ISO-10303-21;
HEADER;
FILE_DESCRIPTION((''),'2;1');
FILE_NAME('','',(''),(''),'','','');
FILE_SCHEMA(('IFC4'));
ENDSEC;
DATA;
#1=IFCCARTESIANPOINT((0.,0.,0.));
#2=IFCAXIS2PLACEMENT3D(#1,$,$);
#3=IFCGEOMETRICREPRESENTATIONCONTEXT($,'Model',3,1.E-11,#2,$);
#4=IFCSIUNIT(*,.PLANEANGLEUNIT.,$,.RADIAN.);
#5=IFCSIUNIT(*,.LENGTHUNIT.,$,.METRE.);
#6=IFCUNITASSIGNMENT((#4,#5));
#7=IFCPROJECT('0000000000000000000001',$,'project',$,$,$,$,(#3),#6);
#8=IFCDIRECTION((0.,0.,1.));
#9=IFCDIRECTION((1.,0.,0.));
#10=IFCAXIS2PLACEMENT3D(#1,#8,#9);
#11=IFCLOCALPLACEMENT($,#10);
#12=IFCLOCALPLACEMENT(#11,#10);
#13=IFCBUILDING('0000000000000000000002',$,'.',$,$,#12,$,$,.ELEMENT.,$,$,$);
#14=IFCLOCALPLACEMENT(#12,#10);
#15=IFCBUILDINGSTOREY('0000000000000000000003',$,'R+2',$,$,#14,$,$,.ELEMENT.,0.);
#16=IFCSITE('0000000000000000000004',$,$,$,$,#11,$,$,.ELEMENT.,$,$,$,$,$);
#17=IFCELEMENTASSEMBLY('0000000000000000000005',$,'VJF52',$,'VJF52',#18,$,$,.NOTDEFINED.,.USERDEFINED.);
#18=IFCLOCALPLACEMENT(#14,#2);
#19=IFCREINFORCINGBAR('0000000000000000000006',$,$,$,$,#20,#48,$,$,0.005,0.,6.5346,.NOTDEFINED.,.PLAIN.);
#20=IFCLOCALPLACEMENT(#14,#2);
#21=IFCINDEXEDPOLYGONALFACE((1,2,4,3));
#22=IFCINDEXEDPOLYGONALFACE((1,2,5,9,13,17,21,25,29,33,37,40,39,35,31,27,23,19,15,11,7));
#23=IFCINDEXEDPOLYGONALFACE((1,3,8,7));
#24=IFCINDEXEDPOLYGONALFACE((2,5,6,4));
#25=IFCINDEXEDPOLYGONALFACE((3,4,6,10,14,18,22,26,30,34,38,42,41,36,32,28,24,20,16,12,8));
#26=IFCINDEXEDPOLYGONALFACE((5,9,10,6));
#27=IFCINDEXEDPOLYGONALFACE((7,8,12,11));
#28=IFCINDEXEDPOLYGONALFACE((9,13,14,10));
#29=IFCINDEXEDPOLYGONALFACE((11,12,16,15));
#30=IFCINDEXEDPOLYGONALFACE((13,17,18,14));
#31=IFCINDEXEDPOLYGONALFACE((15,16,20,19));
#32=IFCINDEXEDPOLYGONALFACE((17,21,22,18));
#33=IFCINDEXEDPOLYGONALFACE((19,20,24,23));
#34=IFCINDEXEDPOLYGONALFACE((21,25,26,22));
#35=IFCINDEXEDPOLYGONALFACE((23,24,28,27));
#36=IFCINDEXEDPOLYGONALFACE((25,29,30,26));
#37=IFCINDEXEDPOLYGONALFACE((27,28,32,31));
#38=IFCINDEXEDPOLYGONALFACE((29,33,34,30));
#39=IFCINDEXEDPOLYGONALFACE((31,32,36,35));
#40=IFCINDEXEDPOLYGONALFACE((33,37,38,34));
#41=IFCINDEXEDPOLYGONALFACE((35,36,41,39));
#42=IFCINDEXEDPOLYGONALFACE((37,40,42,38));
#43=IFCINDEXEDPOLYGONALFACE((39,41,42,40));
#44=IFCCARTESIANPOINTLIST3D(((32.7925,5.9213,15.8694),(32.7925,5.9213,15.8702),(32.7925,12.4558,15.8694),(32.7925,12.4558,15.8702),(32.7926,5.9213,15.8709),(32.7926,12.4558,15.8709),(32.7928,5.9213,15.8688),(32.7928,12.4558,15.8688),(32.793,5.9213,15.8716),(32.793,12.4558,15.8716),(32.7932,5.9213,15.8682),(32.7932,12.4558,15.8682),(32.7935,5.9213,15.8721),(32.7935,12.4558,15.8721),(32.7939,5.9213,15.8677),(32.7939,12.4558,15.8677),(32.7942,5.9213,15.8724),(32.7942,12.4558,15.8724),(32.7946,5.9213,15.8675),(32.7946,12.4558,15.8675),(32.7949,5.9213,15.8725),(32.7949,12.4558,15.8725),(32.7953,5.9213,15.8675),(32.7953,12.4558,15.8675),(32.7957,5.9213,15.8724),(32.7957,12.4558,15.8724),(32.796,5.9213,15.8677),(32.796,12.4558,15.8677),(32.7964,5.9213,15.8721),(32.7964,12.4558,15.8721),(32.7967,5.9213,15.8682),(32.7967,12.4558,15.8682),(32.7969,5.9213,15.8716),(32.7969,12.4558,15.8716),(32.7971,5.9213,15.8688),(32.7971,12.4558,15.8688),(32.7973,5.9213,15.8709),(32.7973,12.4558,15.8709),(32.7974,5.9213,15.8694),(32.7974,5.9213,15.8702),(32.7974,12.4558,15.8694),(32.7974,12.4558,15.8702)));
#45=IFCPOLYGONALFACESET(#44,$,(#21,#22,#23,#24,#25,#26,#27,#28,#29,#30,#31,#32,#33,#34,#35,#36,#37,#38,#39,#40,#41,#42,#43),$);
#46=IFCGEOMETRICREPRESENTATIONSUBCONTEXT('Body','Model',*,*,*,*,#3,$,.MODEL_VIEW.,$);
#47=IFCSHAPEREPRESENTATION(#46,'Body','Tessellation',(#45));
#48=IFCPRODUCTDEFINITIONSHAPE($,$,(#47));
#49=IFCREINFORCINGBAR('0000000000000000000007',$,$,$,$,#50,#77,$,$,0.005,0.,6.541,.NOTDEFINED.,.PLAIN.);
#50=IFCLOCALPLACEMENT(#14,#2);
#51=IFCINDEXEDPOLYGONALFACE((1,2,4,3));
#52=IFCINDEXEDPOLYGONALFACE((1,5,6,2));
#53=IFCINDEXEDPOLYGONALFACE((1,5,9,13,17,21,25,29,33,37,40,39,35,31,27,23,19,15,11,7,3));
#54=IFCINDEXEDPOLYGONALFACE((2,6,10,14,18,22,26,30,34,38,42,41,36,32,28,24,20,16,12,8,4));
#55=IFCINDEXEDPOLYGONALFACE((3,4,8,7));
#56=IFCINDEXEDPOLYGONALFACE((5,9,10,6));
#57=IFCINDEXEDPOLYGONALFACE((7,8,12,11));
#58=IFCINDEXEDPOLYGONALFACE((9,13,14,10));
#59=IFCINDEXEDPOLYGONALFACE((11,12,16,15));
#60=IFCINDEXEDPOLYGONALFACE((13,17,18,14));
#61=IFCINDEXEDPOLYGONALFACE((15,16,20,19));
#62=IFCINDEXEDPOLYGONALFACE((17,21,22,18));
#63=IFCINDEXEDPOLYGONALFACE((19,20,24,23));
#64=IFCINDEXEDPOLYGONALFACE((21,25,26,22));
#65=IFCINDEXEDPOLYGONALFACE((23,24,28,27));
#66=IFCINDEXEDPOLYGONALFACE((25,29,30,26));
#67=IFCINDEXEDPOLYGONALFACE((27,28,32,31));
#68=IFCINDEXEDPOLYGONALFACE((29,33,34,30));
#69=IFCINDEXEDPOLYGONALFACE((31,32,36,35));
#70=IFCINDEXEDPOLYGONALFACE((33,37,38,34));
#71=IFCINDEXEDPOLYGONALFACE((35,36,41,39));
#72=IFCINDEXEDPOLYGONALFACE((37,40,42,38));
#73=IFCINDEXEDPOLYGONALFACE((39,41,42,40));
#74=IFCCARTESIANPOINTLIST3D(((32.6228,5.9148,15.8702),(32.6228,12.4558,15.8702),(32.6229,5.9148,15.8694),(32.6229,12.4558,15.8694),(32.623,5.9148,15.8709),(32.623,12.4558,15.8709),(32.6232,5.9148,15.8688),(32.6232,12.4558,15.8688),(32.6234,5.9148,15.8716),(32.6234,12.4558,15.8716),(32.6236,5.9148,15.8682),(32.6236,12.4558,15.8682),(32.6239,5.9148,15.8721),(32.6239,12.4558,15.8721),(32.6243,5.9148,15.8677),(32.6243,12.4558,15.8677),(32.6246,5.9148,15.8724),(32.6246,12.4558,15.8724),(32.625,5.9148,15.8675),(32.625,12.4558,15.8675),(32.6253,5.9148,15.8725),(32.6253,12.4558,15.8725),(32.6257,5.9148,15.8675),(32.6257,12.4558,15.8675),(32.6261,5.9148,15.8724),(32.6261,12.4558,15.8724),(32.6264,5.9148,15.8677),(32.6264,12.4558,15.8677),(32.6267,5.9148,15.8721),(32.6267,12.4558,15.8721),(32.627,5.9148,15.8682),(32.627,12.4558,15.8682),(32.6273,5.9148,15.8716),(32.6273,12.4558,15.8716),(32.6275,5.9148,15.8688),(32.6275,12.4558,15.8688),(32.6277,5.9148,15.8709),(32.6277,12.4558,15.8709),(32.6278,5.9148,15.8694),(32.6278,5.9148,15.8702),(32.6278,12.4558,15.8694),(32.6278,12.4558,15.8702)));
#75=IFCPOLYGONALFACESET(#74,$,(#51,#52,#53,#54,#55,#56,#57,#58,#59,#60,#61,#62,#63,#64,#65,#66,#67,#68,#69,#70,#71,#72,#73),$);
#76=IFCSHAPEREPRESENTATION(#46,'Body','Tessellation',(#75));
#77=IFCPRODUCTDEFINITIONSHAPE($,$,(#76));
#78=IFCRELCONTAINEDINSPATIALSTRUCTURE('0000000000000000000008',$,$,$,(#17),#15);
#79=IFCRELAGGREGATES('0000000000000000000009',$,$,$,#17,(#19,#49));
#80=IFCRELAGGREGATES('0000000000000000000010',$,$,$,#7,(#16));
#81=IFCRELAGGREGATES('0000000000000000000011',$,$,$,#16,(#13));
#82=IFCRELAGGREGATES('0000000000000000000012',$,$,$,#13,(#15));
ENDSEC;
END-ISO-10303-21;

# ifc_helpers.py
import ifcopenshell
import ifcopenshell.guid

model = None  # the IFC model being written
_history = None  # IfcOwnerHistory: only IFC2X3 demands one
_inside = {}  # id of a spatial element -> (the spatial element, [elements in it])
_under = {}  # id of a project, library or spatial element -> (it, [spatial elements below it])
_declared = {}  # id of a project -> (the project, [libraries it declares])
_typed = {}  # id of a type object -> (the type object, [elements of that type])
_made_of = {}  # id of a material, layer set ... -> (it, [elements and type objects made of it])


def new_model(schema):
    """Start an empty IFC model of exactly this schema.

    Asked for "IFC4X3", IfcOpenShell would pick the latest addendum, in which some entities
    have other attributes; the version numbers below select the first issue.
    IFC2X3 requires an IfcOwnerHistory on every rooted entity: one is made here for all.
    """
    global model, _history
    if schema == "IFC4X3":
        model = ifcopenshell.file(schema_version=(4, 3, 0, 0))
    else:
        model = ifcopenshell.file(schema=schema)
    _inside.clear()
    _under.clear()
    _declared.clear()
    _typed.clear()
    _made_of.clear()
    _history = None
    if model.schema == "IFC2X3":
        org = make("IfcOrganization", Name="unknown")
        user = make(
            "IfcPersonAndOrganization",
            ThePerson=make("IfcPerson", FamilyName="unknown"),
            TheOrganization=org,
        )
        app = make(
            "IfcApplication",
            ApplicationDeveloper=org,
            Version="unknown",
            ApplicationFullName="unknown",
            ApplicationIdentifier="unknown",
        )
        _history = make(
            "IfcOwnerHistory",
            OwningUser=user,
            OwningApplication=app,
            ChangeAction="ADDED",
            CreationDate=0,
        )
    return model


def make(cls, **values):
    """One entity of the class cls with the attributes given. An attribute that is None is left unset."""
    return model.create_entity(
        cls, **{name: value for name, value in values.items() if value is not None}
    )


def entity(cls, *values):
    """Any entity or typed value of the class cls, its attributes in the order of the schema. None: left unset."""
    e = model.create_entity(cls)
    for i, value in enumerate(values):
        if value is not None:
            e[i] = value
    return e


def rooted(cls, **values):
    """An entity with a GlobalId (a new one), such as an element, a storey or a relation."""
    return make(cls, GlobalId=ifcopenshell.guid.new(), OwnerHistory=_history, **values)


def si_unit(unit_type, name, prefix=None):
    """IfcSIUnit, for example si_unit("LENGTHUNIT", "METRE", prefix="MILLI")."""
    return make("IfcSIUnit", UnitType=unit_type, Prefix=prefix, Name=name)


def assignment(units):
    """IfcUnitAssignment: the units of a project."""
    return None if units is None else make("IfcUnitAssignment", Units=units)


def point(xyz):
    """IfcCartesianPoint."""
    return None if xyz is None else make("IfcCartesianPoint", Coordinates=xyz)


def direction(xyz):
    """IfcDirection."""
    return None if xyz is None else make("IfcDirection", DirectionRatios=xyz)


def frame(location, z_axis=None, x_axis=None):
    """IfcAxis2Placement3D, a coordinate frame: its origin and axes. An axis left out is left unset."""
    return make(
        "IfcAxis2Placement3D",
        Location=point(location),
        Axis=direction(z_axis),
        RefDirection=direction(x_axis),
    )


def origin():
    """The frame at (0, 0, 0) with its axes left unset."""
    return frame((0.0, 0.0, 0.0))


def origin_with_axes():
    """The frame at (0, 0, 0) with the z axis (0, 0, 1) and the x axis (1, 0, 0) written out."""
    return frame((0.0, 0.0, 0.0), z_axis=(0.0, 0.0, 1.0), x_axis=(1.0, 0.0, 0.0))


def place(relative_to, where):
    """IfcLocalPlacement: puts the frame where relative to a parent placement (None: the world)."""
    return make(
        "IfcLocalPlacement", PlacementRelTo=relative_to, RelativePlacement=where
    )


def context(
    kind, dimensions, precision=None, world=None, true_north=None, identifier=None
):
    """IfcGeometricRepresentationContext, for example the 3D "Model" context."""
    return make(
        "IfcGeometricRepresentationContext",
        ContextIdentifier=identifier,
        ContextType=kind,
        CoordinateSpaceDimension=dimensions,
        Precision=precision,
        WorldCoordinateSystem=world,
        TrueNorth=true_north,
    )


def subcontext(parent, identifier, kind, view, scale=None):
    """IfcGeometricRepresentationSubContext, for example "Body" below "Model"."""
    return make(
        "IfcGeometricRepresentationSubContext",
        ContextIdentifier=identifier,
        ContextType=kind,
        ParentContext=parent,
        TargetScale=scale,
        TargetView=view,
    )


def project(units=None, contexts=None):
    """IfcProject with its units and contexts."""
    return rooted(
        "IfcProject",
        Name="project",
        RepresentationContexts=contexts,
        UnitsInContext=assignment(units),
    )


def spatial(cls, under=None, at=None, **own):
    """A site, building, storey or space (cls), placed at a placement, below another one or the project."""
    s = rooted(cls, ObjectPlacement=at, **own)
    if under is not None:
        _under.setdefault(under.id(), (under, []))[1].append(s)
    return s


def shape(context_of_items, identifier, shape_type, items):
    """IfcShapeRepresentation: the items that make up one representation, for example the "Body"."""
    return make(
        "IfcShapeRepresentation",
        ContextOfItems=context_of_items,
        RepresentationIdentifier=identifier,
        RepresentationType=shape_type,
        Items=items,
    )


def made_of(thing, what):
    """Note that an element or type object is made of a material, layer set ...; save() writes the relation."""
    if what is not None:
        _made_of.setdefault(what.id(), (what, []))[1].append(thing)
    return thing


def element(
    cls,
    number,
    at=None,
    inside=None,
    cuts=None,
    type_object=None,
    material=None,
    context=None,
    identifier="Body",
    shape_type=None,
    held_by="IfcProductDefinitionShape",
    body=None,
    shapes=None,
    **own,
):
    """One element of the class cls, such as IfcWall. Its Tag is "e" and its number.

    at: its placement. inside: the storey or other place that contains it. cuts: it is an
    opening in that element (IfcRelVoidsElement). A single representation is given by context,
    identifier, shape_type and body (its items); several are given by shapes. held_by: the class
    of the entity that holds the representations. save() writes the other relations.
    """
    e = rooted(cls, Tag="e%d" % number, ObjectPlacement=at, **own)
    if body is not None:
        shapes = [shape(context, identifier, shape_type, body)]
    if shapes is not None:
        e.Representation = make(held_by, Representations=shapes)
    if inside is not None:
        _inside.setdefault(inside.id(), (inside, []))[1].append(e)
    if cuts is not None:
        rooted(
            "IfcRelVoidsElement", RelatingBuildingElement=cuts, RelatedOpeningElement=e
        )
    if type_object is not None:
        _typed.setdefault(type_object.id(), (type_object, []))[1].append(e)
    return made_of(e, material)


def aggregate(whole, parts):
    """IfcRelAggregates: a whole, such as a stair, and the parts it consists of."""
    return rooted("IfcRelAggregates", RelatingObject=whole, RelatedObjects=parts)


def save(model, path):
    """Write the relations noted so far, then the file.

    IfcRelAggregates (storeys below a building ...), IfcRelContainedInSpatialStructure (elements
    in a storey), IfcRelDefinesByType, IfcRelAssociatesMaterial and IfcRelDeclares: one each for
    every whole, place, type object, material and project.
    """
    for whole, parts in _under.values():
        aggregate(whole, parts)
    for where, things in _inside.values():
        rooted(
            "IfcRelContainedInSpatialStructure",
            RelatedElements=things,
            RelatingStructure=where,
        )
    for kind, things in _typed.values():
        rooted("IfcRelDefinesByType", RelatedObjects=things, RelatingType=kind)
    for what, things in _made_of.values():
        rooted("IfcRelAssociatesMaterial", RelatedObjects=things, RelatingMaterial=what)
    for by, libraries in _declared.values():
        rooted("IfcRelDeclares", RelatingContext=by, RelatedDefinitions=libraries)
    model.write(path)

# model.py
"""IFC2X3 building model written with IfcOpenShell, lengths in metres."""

from ifc_helpers import new_model, entity, si_unit, origin, origin_with_axes, place, context, subcontext, project, spatial, shape, element, aggregate, save


model = new_model("IFC2X3")

# Units and contexts
model_context = context("Model", 3, precision=1e-11, world=origin())
body_context = subcontext(model_context, "Body", "Model", "MODEL_VIEW")
ifc_project = project(units=[si_unit("PLANEANGLEUNIT", "RADIAN"), si_unit("LENGTHUNIT", "METRE")], contexts=[model_context])

# Site, building, storey
site_placement = place(None, origin_with_axes())
site = spatial("IfcSite", under=ifc_project, at=site_placement, CompositionType="ELEMENT")
building_placement = place(site_placement, origin_with_axes())
building = spatial("IfcBuilding", under=site, at=building_placement, Name=".", CompositionType="ELEMENT")
storey_placement = place(building_placement, origin_with_axes())
storey = spatial("IfcBuildingStorey", under=building, at=storey_placement, Name="R+2", CompositionType="ELEMENT", Elevation=0.0)

# Element assembly, reinforcing bars
assembly_1_placement = place(storey_placement, origin_with_axes())
assembly_1 = element("IfcElementAssembly", 1, at=assembly_1_placement, inside=storey, Name="VJF52", ObjectType="VJF52", AssemblyPlace="NOTDEFINED", PredefinedType="USERDEFINED")
reinforcing_bar_1_placement = place(assembly_1_placement, origin_with_axes())
reinforcing_bar_1 = element("IfcReinforcingBar", 2, at=reinforcing_bar_1_placement, BarLength=6.5346, BarRole="NOTDEFINED", BarSurface="PLAIN", CrossSectionArea=0.0, NominalDiameter=0.005, shapes=[
    shape(body_context, "Body", "AdvancedSweptSolid", [entity("IfcSweptDiskSolid", entity("IfcPolyline", [entity("IfcCartesianPoint", [32.7949, 5.9213, 15.87]), entity("IfcCartesianPoint", [32.7949, 12.4558, 15.87])]), 0.0025, None, 0.0, 6.5346)]),
    shape(body_context, "Body", "AdvancedSweptSolid", [entity("IfcSweptDiskSolid", entity("IfcPolyline", [entity("IfcCartesianPoint", [32.7949, 5.9213, 15.87]), entity("IfcCartesianPoint", [32.7949, 12.4558, 15.87])]), 0.0025, None, 0.0, 6.5346)]),
])
reinforcing_bar_2_placement = place(assembly_1_placement, origin_with_axes())
reinforcing_bar_2 = element("IfcReinforcingBar", 3, at=reinforcing_bar_2_placement, BarLength=6.541, BarRole="NOTDEFINED", BarSurface="PLAIN", CrossSectionArea=0.0, NominalDiameter=0.005, shapes=[
    shape(body_context, "Body", "AdvancedSweptSolid", [entity("IfcSweptDiskSolid", entity("IfcPolyline", [entity("IfcCartesianPoint", [32.6253, 5.9148, 15.87]), entity("IfcCartesianPoint", [32.6253, 12.4558, 15.87])]), 0.0025, None, 0.0, 6.541)]),
    shape(body_context, "Body", "AdvancedSweptSolid", [entity("IfcSweptDiskSolid", entity("IfcPolyline", [entity("IfcCartesianPoint", [32.6253, 5.9148, 15.87]), entity("IfcCartesianPoint", [32.6253, 12.4558, 15.87])]), 0.0025, None, 0.0, 6.541)]),
])
aggregate(assembly_1, [reinforcing_bar_1, reinforcing_bar_2])

save(model, "model.ifc")
